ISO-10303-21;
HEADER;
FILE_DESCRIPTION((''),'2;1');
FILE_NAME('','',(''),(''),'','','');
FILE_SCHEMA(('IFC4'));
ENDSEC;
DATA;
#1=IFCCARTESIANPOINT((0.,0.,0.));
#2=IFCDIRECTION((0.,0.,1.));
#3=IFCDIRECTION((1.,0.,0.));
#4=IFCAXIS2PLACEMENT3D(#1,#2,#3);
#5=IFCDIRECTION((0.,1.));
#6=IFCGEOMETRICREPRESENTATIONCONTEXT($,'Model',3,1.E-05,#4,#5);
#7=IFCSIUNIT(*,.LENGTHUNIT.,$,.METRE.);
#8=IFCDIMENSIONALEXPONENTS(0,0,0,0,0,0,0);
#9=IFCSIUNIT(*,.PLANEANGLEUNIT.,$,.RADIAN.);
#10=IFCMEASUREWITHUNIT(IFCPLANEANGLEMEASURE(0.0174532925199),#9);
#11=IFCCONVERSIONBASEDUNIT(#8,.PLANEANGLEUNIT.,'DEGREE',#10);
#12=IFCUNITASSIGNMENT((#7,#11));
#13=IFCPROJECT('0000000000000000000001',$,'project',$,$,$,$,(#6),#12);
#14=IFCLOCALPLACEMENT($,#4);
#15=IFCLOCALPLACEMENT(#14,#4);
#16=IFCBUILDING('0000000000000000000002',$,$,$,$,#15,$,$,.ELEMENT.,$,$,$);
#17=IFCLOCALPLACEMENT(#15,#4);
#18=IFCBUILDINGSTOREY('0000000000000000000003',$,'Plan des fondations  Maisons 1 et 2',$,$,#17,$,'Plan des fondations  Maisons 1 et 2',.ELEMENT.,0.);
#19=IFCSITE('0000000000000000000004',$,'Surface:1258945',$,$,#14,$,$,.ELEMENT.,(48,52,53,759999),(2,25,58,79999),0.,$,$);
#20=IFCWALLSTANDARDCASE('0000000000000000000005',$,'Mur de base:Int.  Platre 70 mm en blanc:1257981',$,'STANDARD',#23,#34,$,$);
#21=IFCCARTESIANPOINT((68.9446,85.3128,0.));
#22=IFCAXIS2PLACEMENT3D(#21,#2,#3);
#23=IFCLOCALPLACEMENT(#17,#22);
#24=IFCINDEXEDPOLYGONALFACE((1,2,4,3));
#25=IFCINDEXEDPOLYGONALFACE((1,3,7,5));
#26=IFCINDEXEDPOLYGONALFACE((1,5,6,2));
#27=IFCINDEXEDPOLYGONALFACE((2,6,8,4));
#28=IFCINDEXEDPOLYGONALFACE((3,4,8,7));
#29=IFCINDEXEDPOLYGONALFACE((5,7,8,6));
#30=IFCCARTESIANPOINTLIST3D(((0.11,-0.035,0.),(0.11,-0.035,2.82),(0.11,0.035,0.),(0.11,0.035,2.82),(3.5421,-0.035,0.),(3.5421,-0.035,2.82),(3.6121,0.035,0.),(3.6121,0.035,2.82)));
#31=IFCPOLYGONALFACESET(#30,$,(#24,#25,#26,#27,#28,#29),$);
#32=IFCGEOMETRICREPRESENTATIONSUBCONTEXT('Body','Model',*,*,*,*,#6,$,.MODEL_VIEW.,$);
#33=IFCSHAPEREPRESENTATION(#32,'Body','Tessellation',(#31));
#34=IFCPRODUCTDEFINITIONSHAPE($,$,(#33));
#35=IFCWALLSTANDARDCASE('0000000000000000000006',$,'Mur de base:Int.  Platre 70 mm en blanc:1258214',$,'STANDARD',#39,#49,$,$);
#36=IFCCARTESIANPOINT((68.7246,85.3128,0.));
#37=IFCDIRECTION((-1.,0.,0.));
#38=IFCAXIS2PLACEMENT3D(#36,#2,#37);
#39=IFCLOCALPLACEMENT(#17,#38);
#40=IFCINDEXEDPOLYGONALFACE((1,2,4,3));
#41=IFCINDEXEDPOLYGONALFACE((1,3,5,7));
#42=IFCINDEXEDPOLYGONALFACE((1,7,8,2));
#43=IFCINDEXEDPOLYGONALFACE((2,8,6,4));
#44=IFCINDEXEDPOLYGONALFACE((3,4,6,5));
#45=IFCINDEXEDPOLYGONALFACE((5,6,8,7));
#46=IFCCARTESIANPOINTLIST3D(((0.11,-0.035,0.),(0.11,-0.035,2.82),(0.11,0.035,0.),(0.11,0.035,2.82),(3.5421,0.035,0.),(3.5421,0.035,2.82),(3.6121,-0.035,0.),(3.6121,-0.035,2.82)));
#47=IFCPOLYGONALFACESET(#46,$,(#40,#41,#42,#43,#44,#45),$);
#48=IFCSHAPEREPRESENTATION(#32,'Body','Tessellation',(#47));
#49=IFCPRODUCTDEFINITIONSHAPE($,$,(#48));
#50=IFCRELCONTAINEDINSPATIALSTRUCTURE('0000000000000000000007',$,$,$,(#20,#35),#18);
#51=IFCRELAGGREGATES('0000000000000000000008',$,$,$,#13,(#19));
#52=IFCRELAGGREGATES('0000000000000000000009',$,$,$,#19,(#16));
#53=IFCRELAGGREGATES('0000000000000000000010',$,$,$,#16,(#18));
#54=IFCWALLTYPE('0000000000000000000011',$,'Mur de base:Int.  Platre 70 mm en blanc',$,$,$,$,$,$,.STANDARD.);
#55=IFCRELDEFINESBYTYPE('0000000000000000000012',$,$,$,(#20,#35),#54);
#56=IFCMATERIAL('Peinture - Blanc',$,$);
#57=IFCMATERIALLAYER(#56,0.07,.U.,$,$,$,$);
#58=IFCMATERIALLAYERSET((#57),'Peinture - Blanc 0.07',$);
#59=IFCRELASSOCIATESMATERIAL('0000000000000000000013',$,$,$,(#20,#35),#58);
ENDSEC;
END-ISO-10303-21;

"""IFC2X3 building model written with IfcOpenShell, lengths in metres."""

from ifc_helpers import new_model, entity, si_unit, converted_unit, direction, frame, origin_with_axes, place, context, subcontext, project, spatial, polyline, outline, extrude, material, layer, layer_set, layer_usage, type_object, element, save


model = new_model("IFC2X3")

# Units and contexts
model_context = context("Model", 3, precision=1e-05, world=origin_with_axes(), true_north=direction((0.0, 1.0)))
body_context = subcontext(model_context, "Body", "Model", "MODEL_VIEW")
ifc_project = project(units=[si_unit("LENGTHUNIT", "METRE"), converted_unit("PLANEANGLEUNIT", "DEGREE", entity("IfcPlaneAngleMeasure", 0.0174532925199), si_unit("PLANEANGLEUNIT", "RADIAN"), dimensions=[0, 0, 0, 0, 0, 0, 0])], contexts=[model_context])

# Site, building, storey
site_placement = place(None, origin_with_axes())
site = spatial("IfcSite", under=ifc_project, at=site_placement, Name="Surface:1258945", CompositionType="ELEMENT", RefLatitude=(48, 52, 53, 759999), RefLongitude=(2, 25, 58, 79999), RefElevation=0.0)
building_placement = place(site_placement, origin_with_axes())
building = spatial("IfcBuilding", under=site, at=building_placement, CompositionType="ELEMENT")
storey_placement = place(building_placement, origin_with_axes())
storey = spatial("IfcBuildingStorey", under=building, at=storey_placement, Name="Plan des fondations  Maisons 1 et 2", LongName="Plan des fondations  Maisons 1 et 2", CompositionType="ELEMENT", Elevation=0.0)

# Shared definitions
ifc_material_1 = material(Name="Peinture - Blanc")

# Walls
ifc_layer_1 = layer(ifc_material_1, 0.07, ventilated="UNKNOWN")
ifc_layer_set_1 = layer_set([ifc_layer_1], Name="Peinture - Blanc 0.07")
ifc_layer_usage_1 = layer_usage(ifc_layer_set_1, "AXIS2", "POSITIVE", -0.035)
wall_type_1 = type_object("IfcWallType", Name="Mur de base:Int.  Platre 70 mm en blanc", PredefinedType="STANDARD")
wall_1_placement = place(storey_placement, frame((68.9446, 85.3128, 0.0), z_axis=(0.0, 0.0, 1.0), x_axis=(1.0, 0.0, 0.0)))
element("IfcWallStandardCase", 1, at=wall_1_placement, inside=storey, type_object=wall_type_1, material=ifc_layer_usage_1, Name="Mur de base:Int.  Platre 70 mm en blanc:1257981", ObjectType="STANDARD", context=body_context, shape_type="SweptSolid", body=[
    extrude(outline(polyline([(0.11, -0.035), (3.5421, -0.035), (3.6121, 0.035), (0.11, 0.035), (0.11, -0.035)])), origin_with_axes(), (0.0, 0.0, 1.0), 2.82),
])
ifc_layer_usage_2 = layer_usage(ifc_layer_set_1, "AXIS2", "POSITIVE", -0.035)
wall_2_placement = place(storey_placement, frame((68.7246, 85.3128, 0.0), z_axis=(0.0, 0.0, 1.0), x_axis=(-1.0, 0.0, 0.0)))
element("IfcWallStandardCase", 2, at=wall_2_placement, inside=storey, type_object=wall_type_1, material=ifc_layer_usage_2, Name="Mur de base:Int.  Platre 70 mm en blanc:1258214", ObjectType="STANDARD", context=body_context, shape_type="SweptSolid", body=[
    extrude(outline(polyline([(0.11, -0.035), (3.6121, -0.035), (3.5421, 0.035), (0.11, 0.035), (0.11, -0.035)])), origin_with_axes(), (0.0, 0.0, 1.0), 2.82),
])

save(model, "model.ifc")
